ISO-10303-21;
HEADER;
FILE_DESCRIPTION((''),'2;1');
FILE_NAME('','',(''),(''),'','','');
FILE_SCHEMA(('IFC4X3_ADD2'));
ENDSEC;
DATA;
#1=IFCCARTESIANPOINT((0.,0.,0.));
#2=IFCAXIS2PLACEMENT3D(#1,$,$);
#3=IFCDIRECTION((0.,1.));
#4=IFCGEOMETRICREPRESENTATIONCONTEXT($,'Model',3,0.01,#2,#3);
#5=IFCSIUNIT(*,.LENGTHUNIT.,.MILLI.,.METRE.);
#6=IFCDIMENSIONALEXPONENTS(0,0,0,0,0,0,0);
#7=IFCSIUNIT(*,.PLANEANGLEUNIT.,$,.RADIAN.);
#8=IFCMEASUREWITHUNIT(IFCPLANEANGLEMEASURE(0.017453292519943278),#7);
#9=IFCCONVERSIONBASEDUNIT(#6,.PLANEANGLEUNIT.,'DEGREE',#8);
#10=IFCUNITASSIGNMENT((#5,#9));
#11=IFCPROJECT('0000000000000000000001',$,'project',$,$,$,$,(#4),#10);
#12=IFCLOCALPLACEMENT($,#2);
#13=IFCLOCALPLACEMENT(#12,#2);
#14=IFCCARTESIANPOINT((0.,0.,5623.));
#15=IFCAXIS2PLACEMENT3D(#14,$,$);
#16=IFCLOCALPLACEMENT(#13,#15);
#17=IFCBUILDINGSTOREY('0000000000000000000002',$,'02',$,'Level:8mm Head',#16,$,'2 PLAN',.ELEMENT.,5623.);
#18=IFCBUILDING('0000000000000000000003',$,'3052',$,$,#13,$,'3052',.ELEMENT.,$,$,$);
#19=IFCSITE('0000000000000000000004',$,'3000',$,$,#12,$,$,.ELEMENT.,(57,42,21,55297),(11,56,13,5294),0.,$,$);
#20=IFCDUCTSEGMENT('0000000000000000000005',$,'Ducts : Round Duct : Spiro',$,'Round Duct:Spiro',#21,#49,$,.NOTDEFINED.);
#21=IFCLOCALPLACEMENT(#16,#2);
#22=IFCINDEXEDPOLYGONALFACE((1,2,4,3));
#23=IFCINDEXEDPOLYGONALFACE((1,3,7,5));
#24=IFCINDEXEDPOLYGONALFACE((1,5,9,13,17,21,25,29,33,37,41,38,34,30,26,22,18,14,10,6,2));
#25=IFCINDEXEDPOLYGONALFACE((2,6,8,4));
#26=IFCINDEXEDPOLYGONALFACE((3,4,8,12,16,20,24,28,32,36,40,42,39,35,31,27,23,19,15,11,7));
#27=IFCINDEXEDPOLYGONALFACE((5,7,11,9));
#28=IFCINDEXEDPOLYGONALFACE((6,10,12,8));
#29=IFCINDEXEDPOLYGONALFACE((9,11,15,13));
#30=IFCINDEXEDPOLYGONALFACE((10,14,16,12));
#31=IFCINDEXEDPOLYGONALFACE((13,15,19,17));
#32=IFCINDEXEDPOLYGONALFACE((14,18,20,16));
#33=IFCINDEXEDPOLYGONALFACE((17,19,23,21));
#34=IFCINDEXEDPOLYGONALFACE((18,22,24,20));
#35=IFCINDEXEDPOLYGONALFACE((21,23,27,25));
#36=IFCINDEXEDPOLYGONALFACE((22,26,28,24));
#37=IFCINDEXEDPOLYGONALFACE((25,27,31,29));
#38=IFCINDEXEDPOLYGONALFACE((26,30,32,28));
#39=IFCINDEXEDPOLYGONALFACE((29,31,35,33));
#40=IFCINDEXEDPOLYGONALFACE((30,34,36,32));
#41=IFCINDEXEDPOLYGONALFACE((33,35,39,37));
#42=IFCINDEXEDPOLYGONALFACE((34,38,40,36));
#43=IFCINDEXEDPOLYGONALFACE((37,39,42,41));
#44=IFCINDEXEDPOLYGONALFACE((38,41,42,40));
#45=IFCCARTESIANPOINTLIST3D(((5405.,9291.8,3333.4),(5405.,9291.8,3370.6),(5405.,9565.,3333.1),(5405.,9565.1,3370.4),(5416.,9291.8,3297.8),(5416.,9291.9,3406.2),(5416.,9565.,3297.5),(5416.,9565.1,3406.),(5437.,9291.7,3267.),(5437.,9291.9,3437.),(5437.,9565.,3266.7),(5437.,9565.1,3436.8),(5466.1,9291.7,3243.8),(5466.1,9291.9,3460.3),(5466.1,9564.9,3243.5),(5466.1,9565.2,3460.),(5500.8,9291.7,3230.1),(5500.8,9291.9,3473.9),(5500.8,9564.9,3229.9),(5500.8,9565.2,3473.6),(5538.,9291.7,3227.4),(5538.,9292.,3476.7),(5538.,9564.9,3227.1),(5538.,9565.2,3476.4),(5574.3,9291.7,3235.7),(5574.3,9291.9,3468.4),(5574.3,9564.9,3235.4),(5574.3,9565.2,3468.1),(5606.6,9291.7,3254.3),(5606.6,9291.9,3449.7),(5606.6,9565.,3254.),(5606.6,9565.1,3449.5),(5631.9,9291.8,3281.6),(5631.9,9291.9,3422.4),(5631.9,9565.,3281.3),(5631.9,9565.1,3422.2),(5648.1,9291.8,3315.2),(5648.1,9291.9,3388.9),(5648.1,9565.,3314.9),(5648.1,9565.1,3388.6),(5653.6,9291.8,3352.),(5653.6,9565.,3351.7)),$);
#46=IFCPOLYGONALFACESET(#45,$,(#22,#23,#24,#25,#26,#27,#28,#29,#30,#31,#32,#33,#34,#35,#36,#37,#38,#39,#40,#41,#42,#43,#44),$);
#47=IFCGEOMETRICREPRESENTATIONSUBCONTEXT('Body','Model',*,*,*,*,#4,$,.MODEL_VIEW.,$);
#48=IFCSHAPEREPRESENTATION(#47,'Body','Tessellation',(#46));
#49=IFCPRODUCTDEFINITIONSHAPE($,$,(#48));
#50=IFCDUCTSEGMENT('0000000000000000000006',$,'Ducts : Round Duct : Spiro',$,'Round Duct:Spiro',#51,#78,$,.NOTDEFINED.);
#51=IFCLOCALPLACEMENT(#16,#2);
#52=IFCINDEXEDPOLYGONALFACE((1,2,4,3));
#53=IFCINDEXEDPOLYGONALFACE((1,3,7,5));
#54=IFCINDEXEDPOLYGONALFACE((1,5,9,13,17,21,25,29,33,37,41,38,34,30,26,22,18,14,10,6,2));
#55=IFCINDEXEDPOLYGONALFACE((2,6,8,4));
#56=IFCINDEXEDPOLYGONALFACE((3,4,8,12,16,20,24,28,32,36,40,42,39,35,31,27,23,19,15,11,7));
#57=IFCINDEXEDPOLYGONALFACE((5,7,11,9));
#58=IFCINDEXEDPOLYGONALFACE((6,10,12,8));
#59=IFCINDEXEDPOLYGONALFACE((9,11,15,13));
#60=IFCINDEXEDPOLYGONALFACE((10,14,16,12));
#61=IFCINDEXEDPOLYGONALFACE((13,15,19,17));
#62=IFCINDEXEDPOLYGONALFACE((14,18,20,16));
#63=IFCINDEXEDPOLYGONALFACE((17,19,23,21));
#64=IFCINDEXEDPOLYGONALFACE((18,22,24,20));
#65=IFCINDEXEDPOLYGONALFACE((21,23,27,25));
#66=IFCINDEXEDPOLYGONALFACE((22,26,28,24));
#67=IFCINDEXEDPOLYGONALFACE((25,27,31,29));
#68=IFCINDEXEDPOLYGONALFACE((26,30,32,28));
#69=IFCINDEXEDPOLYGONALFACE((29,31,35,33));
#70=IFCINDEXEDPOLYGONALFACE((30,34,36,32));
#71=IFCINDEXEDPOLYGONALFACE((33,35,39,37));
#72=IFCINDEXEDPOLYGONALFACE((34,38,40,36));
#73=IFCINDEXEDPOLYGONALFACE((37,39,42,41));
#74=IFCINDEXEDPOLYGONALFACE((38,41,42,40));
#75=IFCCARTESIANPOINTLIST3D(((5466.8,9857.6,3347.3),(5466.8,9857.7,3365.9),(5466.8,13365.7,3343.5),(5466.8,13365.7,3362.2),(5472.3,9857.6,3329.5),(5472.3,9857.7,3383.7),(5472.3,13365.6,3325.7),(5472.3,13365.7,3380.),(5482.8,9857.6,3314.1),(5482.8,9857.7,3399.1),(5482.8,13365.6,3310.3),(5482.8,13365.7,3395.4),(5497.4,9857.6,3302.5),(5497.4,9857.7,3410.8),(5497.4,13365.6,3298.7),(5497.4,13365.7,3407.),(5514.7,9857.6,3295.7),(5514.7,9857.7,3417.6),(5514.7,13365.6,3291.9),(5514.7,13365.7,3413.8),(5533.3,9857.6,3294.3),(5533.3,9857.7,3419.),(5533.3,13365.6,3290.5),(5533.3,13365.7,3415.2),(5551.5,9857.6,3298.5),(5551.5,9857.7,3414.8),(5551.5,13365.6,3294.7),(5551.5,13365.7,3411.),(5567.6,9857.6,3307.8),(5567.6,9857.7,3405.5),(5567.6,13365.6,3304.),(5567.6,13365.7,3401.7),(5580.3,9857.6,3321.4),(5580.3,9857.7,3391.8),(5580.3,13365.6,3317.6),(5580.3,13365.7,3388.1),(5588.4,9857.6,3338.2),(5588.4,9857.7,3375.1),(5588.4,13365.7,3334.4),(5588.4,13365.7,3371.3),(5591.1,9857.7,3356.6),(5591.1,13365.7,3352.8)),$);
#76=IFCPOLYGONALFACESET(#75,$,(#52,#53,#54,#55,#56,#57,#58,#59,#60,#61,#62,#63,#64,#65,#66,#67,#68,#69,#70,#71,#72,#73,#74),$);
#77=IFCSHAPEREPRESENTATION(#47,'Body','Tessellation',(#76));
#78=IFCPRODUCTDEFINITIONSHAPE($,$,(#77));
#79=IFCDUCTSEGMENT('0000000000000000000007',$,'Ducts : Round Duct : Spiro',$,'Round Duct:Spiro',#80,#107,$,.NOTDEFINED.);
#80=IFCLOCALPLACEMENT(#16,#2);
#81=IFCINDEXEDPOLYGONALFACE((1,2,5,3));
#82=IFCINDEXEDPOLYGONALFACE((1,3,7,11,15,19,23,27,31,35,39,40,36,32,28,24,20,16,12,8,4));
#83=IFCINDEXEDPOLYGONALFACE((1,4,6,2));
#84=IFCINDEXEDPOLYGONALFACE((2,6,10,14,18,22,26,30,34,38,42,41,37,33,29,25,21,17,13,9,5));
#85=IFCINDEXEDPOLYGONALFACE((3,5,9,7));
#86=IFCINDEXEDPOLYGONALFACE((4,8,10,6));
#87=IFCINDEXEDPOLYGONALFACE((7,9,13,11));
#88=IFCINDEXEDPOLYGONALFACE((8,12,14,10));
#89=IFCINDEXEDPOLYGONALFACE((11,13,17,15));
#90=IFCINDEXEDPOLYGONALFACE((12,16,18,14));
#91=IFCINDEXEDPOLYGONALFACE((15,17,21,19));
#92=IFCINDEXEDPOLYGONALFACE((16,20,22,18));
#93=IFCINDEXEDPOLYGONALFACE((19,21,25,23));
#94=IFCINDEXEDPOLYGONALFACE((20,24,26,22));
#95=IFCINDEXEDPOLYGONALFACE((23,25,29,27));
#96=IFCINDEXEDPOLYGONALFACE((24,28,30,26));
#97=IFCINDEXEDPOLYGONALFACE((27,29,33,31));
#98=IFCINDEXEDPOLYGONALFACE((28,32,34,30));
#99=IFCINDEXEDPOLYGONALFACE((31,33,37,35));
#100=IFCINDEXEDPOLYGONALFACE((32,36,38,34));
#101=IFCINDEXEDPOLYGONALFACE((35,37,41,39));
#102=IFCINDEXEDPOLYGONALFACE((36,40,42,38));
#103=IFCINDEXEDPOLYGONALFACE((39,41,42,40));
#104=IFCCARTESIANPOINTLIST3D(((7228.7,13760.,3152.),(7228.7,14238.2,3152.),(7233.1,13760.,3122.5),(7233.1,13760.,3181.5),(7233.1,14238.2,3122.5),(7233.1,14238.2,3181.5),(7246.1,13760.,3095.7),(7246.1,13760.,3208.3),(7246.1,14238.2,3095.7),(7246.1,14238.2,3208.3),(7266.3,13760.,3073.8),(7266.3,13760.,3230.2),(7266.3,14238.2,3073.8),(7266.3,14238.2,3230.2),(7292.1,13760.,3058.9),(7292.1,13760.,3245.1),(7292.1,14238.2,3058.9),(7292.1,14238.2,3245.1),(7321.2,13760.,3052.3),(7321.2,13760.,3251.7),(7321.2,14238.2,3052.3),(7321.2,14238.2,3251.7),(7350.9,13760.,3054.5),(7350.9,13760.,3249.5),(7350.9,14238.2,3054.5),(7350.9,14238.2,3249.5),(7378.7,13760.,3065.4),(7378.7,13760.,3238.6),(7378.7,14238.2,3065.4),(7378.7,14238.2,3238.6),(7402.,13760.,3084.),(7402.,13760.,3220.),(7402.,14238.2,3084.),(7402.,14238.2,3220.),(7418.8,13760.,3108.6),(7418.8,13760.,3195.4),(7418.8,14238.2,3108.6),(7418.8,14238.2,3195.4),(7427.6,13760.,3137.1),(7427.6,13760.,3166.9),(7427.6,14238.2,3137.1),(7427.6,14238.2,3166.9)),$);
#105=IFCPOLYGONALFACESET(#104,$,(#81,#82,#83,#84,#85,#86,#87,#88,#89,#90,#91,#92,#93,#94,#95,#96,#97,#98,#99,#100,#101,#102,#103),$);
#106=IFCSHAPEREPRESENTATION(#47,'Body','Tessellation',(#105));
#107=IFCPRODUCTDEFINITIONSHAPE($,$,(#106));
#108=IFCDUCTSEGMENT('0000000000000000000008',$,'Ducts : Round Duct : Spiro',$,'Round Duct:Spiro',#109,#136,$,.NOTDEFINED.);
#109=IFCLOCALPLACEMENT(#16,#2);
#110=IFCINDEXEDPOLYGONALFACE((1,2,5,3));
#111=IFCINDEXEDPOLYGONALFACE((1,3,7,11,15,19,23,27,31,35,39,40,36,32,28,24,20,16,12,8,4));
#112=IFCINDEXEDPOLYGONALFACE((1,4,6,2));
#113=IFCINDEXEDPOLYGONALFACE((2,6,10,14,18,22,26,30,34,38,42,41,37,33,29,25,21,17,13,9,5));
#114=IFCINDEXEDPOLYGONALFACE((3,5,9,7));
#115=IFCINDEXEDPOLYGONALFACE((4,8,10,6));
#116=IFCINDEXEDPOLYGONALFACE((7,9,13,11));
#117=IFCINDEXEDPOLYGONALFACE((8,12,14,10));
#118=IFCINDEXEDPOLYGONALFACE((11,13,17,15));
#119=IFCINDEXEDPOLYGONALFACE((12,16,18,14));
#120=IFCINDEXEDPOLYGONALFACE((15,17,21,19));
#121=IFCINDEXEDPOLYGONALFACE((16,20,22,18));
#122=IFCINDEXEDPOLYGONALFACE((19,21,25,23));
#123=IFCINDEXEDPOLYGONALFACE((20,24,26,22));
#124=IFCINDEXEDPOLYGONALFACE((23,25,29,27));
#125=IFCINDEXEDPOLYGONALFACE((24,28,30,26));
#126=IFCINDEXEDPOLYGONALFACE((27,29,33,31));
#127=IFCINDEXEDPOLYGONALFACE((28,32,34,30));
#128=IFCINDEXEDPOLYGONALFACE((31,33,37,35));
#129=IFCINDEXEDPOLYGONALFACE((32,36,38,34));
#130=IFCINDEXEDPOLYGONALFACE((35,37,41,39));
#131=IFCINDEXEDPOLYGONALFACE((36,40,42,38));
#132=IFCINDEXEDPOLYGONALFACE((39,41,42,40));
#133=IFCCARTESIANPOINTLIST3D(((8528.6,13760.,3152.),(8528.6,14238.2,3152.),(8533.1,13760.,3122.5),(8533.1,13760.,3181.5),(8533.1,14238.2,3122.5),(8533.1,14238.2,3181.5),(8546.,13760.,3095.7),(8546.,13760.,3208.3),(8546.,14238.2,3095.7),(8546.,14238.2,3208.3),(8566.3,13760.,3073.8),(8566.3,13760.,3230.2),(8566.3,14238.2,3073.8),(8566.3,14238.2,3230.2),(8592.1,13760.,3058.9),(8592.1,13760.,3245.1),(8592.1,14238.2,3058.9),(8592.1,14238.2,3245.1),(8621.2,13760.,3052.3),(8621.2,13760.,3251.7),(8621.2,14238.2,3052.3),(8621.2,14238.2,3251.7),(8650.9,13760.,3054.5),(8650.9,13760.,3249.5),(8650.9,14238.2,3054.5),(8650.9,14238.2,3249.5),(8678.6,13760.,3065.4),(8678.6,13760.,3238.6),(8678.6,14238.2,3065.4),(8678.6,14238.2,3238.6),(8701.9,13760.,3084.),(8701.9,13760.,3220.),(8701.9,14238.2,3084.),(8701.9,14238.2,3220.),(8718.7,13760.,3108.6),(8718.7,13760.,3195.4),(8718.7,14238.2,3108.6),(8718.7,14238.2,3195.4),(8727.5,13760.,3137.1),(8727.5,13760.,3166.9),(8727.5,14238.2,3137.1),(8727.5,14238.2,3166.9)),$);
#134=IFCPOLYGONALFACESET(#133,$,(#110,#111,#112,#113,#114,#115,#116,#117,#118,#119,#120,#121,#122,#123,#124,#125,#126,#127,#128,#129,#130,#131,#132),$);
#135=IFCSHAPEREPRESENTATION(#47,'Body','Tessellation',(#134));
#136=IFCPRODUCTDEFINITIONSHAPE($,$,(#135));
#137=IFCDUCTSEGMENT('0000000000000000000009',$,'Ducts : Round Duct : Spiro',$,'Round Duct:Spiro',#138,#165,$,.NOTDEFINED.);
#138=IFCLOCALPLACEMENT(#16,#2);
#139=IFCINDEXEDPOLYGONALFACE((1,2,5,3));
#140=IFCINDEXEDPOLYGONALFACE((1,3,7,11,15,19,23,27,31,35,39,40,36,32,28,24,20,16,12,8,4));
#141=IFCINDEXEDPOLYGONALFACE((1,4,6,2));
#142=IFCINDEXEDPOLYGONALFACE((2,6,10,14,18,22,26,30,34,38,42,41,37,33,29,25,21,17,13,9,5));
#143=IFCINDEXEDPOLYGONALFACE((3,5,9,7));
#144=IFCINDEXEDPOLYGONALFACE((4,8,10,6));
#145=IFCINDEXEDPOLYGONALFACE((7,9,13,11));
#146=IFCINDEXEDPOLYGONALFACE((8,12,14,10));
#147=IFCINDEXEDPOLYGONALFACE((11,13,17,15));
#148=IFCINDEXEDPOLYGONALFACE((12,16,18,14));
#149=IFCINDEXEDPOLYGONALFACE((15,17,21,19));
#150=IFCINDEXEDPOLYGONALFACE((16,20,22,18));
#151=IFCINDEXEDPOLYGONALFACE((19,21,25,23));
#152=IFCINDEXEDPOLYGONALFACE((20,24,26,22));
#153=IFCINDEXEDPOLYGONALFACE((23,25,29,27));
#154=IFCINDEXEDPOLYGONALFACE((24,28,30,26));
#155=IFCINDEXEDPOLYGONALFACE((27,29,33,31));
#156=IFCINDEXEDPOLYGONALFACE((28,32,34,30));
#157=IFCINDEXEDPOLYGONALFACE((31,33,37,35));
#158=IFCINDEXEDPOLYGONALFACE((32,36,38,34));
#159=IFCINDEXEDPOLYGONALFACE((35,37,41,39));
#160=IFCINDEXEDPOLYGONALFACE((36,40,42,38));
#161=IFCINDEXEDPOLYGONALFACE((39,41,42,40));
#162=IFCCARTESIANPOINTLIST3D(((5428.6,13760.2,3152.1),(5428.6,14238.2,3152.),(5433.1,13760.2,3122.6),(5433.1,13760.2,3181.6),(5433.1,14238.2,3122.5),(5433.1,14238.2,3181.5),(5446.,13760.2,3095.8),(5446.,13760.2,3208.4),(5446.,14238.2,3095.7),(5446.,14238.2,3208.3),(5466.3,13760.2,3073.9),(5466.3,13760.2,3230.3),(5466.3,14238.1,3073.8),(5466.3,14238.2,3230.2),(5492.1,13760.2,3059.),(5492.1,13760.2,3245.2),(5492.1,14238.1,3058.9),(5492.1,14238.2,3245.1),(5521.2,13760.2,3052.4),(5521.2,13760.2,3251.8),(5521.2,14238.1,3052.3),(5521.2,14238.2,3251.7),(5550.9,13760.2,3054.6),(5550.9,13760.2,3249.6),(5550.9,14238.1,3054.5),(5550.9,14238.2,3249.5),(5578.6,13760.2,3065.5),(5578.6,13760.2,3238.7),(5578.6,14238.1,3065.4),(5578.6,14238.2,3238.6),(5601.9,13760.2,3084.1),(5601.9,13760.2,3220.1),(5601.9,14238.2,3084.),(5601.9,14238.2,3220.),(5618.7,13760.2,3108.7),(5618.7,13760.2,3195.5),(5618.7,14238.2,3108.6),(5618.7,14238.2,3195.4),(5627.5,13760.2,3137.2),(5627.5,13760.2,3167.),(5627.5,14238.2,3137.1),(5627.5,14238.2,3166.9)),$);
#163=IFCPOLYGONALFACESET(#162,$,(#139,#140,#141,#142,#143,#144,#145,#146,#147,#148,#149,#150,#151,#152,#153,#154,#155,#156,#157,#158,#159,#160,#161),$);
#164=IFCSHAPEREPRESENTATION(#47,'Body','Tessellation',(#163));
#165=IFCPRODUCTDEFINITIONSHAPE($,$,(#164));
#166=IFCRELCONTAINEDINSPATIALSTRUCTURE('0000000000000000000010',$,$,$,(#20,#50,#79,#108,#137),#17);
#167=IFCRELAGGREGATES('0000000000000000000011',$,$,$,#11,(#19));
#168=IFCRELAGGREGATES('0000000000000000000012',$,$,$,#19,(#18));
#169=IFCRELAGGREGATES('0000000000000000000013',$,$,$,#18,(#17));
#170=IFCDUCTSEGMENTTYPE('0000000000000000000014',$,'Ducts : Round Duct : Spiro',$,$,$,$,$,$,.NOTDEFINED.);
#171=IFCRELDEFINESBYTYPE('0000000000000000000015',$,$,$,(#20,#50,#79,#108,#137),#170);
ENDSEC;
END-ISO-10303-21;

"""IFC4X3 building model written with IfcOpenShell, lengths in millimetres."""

from ifc_helpers import new_model, entity, si_unit, converted_unit, direction, frame, frame_2d, origin, origin_2d_with_axis, place, context, subcontext, project, spatial, circle, extrude, type_object, element, save


model = new_model("IFC4X3")

# Units and contexts
model_context = context("Model", 3, precision=0.01, world=origin(), true_north=direction((0.0, 1.0)))
body_context = subcontext(model_context, "Body", "Model", "MODEL_VIEW")
ifc_project = project(units=[si_unit("LENGTHUNIT", "METRE", prefix="MILLI"), converted_unit("PLANEANGLEUNIT", "DEGREE", entity("IfcPlaneAngleMeasure", 0.017453292519943278), si_unit("PLANEANGLEUNIT", "RADIAN"), dimensions=[0, 0, 0, 0, 0, 0, 0])], contexts=[model_context])

# Site, building, storey
site_placement = place(None, origin())
site = spatial("IfcSite", under=ifc_project, at=site_placement, Name="3000", CompositionType="ELEMENT", RefLatitude=(57, 42, 21, 55297), RefLongitude=(11, 56, 13, 5294), RefElevation=0.0)
building_placement = place(site_placement, origin())
building = spatial("IfcBuilding", under=site, at=building_placement, Name="3052", LongName="3052", CompositionType="ELEMENT")
storey_placement = place(building_placement, frame((0.0, 0.0, 5623.0)))
storey = spatial("IfcBuildingStorey", under=building, at=storey_placement, Name="02", ObjectType="Level:8mm Head", LongName="2 PLAN", CompositionType="ELEMENT", Elevation=5623.0)

# Duct segments
duct_segment_type = type_object("IfcDuctSegmentType", Name="Ducts : Round Duct : Spiro", PredefinedType="NOTDEFINED")
duct_segment_1_placement = place(storey_placement, frame((5402.0, 9291.7, 3478.6)))
element("IfcDuctSegment", 1, at=duct_segment_1_placement, inside=storey, type_object=duct_segment_type, Name="Ducts : Round Duct : Spiro", ObjectType="Round Duct:Spiro", PredefinedType="NOTDEFINED", context=body_context, shape_type="SweptSolid", body=[
    extrude(circle(Radius=125.0, at=frame_2d((0.0, 0.0), x_axis=(1.0, 0.0))), frame((126.6, 0.1, -126.6), z_axis=(0.0, 1.0, -0.000973), x_axis=(1.0, 0.0, 0.0)), (0.0, 0.0, 1.0), 273.2),
])
duct_segment_2_placement = place(storey_placement, frame((5464.5, 9857.6, 3420.7)))
element("IfcDuctSegment", 2, at=duct_segment_2_placement, inside=storey, type_object=duct_segment_type, Name="Ducts : Round Duct : Spiro", ObjectType="Round Duct:Spiro", PredefinedType="NOTDEFINED", context=body_context, shape_type="SweptSolid", body=[
    extrude(circle(Radius=62.5, at=origin_2d_with_axis()), frame((64.1, 0.1, -64.1), z_axis=(0.0, 0.999999, -0.001079), x_axis=(1.0, 0.0, 0.0)), (0.0, 0.0, 1.0), 3508.0),
])
duct_segment_3_placement = place(storey_placement, frame((7227.1, 13760.0, 3253.6)))
element("IfcDuctSegment", 3, at=duct_segment_3_placement, inside=storey, type_object=duct_segment_type, Name="Ducts : Round Duct : Spiro", ObjectType="Round Duct:Spiro", PredefinedType="NOTDEFINED", context=body_context, shape_type="SweptSolid", body=[
    extrude(circle(Radius=100.0, at=frame_2d((0.0, 0.0), x_axis=(1.0, 0.0))), frame((101.6, 0.0, -101.6), z_axis=(0.0, 1.0, -0.000009), x_axis=(-1.0, 0.0, 0.0)), (0.0, 0.0, 1.0), 478.2),
])
duct_segment_4_placement = place(storey_placement, frame((8527.0, 13760.0, 3253.6)))
element("IfcDuctSegment", 4, at=duct_segment_4_placement, inside=storey, type_object=duct_segment_type, Name="Ducts : Round Duct : Spiro", ObjectType="Round Duct:Spiro", PredefinedType="NOTDEFINED", context=body_context, shape_type="SweptSolid", body=[
    extrude(circle(Radius=100.0, at=frame_2d((0.0, 0.0), x_axis=(1.0, 0.0))), frame((101.6, 0.0, -101.6), z_axis=(0.0, 1.0, -0.000006), x_axis=(-1.0, 0.0, 0.0)), (0.0, 0.0, 1.0), 478.2),
])
duct_segment_5_placement = place(storey_placement, frame((5427.0, 13760.2, 3253.7)))
element("IfcDuctSegment", 5, at=duct_segment_5_placement, inside=storey, type_object=duct_segment_type, Name="Ducts : Round Duct : Spiro", ObjectType="Round Duct:Spiro", PredefinedType="NOTDEFINED", context=body_context, shape_type="SweptSolid", body=[
    extrude(circle(Radius=100.0, at=frame_2d((0.0, 0.0), x_axis=(1.0, 0.0))), frame((101.6, 0.0, -101.6), z_axis=(0.0, 1.0, -0.000174), x_axis=(-1.0, 0.0, 0.0)), (0.0, 0.0, 1.0), 478.0),
])

save(model, "model.ifc")
